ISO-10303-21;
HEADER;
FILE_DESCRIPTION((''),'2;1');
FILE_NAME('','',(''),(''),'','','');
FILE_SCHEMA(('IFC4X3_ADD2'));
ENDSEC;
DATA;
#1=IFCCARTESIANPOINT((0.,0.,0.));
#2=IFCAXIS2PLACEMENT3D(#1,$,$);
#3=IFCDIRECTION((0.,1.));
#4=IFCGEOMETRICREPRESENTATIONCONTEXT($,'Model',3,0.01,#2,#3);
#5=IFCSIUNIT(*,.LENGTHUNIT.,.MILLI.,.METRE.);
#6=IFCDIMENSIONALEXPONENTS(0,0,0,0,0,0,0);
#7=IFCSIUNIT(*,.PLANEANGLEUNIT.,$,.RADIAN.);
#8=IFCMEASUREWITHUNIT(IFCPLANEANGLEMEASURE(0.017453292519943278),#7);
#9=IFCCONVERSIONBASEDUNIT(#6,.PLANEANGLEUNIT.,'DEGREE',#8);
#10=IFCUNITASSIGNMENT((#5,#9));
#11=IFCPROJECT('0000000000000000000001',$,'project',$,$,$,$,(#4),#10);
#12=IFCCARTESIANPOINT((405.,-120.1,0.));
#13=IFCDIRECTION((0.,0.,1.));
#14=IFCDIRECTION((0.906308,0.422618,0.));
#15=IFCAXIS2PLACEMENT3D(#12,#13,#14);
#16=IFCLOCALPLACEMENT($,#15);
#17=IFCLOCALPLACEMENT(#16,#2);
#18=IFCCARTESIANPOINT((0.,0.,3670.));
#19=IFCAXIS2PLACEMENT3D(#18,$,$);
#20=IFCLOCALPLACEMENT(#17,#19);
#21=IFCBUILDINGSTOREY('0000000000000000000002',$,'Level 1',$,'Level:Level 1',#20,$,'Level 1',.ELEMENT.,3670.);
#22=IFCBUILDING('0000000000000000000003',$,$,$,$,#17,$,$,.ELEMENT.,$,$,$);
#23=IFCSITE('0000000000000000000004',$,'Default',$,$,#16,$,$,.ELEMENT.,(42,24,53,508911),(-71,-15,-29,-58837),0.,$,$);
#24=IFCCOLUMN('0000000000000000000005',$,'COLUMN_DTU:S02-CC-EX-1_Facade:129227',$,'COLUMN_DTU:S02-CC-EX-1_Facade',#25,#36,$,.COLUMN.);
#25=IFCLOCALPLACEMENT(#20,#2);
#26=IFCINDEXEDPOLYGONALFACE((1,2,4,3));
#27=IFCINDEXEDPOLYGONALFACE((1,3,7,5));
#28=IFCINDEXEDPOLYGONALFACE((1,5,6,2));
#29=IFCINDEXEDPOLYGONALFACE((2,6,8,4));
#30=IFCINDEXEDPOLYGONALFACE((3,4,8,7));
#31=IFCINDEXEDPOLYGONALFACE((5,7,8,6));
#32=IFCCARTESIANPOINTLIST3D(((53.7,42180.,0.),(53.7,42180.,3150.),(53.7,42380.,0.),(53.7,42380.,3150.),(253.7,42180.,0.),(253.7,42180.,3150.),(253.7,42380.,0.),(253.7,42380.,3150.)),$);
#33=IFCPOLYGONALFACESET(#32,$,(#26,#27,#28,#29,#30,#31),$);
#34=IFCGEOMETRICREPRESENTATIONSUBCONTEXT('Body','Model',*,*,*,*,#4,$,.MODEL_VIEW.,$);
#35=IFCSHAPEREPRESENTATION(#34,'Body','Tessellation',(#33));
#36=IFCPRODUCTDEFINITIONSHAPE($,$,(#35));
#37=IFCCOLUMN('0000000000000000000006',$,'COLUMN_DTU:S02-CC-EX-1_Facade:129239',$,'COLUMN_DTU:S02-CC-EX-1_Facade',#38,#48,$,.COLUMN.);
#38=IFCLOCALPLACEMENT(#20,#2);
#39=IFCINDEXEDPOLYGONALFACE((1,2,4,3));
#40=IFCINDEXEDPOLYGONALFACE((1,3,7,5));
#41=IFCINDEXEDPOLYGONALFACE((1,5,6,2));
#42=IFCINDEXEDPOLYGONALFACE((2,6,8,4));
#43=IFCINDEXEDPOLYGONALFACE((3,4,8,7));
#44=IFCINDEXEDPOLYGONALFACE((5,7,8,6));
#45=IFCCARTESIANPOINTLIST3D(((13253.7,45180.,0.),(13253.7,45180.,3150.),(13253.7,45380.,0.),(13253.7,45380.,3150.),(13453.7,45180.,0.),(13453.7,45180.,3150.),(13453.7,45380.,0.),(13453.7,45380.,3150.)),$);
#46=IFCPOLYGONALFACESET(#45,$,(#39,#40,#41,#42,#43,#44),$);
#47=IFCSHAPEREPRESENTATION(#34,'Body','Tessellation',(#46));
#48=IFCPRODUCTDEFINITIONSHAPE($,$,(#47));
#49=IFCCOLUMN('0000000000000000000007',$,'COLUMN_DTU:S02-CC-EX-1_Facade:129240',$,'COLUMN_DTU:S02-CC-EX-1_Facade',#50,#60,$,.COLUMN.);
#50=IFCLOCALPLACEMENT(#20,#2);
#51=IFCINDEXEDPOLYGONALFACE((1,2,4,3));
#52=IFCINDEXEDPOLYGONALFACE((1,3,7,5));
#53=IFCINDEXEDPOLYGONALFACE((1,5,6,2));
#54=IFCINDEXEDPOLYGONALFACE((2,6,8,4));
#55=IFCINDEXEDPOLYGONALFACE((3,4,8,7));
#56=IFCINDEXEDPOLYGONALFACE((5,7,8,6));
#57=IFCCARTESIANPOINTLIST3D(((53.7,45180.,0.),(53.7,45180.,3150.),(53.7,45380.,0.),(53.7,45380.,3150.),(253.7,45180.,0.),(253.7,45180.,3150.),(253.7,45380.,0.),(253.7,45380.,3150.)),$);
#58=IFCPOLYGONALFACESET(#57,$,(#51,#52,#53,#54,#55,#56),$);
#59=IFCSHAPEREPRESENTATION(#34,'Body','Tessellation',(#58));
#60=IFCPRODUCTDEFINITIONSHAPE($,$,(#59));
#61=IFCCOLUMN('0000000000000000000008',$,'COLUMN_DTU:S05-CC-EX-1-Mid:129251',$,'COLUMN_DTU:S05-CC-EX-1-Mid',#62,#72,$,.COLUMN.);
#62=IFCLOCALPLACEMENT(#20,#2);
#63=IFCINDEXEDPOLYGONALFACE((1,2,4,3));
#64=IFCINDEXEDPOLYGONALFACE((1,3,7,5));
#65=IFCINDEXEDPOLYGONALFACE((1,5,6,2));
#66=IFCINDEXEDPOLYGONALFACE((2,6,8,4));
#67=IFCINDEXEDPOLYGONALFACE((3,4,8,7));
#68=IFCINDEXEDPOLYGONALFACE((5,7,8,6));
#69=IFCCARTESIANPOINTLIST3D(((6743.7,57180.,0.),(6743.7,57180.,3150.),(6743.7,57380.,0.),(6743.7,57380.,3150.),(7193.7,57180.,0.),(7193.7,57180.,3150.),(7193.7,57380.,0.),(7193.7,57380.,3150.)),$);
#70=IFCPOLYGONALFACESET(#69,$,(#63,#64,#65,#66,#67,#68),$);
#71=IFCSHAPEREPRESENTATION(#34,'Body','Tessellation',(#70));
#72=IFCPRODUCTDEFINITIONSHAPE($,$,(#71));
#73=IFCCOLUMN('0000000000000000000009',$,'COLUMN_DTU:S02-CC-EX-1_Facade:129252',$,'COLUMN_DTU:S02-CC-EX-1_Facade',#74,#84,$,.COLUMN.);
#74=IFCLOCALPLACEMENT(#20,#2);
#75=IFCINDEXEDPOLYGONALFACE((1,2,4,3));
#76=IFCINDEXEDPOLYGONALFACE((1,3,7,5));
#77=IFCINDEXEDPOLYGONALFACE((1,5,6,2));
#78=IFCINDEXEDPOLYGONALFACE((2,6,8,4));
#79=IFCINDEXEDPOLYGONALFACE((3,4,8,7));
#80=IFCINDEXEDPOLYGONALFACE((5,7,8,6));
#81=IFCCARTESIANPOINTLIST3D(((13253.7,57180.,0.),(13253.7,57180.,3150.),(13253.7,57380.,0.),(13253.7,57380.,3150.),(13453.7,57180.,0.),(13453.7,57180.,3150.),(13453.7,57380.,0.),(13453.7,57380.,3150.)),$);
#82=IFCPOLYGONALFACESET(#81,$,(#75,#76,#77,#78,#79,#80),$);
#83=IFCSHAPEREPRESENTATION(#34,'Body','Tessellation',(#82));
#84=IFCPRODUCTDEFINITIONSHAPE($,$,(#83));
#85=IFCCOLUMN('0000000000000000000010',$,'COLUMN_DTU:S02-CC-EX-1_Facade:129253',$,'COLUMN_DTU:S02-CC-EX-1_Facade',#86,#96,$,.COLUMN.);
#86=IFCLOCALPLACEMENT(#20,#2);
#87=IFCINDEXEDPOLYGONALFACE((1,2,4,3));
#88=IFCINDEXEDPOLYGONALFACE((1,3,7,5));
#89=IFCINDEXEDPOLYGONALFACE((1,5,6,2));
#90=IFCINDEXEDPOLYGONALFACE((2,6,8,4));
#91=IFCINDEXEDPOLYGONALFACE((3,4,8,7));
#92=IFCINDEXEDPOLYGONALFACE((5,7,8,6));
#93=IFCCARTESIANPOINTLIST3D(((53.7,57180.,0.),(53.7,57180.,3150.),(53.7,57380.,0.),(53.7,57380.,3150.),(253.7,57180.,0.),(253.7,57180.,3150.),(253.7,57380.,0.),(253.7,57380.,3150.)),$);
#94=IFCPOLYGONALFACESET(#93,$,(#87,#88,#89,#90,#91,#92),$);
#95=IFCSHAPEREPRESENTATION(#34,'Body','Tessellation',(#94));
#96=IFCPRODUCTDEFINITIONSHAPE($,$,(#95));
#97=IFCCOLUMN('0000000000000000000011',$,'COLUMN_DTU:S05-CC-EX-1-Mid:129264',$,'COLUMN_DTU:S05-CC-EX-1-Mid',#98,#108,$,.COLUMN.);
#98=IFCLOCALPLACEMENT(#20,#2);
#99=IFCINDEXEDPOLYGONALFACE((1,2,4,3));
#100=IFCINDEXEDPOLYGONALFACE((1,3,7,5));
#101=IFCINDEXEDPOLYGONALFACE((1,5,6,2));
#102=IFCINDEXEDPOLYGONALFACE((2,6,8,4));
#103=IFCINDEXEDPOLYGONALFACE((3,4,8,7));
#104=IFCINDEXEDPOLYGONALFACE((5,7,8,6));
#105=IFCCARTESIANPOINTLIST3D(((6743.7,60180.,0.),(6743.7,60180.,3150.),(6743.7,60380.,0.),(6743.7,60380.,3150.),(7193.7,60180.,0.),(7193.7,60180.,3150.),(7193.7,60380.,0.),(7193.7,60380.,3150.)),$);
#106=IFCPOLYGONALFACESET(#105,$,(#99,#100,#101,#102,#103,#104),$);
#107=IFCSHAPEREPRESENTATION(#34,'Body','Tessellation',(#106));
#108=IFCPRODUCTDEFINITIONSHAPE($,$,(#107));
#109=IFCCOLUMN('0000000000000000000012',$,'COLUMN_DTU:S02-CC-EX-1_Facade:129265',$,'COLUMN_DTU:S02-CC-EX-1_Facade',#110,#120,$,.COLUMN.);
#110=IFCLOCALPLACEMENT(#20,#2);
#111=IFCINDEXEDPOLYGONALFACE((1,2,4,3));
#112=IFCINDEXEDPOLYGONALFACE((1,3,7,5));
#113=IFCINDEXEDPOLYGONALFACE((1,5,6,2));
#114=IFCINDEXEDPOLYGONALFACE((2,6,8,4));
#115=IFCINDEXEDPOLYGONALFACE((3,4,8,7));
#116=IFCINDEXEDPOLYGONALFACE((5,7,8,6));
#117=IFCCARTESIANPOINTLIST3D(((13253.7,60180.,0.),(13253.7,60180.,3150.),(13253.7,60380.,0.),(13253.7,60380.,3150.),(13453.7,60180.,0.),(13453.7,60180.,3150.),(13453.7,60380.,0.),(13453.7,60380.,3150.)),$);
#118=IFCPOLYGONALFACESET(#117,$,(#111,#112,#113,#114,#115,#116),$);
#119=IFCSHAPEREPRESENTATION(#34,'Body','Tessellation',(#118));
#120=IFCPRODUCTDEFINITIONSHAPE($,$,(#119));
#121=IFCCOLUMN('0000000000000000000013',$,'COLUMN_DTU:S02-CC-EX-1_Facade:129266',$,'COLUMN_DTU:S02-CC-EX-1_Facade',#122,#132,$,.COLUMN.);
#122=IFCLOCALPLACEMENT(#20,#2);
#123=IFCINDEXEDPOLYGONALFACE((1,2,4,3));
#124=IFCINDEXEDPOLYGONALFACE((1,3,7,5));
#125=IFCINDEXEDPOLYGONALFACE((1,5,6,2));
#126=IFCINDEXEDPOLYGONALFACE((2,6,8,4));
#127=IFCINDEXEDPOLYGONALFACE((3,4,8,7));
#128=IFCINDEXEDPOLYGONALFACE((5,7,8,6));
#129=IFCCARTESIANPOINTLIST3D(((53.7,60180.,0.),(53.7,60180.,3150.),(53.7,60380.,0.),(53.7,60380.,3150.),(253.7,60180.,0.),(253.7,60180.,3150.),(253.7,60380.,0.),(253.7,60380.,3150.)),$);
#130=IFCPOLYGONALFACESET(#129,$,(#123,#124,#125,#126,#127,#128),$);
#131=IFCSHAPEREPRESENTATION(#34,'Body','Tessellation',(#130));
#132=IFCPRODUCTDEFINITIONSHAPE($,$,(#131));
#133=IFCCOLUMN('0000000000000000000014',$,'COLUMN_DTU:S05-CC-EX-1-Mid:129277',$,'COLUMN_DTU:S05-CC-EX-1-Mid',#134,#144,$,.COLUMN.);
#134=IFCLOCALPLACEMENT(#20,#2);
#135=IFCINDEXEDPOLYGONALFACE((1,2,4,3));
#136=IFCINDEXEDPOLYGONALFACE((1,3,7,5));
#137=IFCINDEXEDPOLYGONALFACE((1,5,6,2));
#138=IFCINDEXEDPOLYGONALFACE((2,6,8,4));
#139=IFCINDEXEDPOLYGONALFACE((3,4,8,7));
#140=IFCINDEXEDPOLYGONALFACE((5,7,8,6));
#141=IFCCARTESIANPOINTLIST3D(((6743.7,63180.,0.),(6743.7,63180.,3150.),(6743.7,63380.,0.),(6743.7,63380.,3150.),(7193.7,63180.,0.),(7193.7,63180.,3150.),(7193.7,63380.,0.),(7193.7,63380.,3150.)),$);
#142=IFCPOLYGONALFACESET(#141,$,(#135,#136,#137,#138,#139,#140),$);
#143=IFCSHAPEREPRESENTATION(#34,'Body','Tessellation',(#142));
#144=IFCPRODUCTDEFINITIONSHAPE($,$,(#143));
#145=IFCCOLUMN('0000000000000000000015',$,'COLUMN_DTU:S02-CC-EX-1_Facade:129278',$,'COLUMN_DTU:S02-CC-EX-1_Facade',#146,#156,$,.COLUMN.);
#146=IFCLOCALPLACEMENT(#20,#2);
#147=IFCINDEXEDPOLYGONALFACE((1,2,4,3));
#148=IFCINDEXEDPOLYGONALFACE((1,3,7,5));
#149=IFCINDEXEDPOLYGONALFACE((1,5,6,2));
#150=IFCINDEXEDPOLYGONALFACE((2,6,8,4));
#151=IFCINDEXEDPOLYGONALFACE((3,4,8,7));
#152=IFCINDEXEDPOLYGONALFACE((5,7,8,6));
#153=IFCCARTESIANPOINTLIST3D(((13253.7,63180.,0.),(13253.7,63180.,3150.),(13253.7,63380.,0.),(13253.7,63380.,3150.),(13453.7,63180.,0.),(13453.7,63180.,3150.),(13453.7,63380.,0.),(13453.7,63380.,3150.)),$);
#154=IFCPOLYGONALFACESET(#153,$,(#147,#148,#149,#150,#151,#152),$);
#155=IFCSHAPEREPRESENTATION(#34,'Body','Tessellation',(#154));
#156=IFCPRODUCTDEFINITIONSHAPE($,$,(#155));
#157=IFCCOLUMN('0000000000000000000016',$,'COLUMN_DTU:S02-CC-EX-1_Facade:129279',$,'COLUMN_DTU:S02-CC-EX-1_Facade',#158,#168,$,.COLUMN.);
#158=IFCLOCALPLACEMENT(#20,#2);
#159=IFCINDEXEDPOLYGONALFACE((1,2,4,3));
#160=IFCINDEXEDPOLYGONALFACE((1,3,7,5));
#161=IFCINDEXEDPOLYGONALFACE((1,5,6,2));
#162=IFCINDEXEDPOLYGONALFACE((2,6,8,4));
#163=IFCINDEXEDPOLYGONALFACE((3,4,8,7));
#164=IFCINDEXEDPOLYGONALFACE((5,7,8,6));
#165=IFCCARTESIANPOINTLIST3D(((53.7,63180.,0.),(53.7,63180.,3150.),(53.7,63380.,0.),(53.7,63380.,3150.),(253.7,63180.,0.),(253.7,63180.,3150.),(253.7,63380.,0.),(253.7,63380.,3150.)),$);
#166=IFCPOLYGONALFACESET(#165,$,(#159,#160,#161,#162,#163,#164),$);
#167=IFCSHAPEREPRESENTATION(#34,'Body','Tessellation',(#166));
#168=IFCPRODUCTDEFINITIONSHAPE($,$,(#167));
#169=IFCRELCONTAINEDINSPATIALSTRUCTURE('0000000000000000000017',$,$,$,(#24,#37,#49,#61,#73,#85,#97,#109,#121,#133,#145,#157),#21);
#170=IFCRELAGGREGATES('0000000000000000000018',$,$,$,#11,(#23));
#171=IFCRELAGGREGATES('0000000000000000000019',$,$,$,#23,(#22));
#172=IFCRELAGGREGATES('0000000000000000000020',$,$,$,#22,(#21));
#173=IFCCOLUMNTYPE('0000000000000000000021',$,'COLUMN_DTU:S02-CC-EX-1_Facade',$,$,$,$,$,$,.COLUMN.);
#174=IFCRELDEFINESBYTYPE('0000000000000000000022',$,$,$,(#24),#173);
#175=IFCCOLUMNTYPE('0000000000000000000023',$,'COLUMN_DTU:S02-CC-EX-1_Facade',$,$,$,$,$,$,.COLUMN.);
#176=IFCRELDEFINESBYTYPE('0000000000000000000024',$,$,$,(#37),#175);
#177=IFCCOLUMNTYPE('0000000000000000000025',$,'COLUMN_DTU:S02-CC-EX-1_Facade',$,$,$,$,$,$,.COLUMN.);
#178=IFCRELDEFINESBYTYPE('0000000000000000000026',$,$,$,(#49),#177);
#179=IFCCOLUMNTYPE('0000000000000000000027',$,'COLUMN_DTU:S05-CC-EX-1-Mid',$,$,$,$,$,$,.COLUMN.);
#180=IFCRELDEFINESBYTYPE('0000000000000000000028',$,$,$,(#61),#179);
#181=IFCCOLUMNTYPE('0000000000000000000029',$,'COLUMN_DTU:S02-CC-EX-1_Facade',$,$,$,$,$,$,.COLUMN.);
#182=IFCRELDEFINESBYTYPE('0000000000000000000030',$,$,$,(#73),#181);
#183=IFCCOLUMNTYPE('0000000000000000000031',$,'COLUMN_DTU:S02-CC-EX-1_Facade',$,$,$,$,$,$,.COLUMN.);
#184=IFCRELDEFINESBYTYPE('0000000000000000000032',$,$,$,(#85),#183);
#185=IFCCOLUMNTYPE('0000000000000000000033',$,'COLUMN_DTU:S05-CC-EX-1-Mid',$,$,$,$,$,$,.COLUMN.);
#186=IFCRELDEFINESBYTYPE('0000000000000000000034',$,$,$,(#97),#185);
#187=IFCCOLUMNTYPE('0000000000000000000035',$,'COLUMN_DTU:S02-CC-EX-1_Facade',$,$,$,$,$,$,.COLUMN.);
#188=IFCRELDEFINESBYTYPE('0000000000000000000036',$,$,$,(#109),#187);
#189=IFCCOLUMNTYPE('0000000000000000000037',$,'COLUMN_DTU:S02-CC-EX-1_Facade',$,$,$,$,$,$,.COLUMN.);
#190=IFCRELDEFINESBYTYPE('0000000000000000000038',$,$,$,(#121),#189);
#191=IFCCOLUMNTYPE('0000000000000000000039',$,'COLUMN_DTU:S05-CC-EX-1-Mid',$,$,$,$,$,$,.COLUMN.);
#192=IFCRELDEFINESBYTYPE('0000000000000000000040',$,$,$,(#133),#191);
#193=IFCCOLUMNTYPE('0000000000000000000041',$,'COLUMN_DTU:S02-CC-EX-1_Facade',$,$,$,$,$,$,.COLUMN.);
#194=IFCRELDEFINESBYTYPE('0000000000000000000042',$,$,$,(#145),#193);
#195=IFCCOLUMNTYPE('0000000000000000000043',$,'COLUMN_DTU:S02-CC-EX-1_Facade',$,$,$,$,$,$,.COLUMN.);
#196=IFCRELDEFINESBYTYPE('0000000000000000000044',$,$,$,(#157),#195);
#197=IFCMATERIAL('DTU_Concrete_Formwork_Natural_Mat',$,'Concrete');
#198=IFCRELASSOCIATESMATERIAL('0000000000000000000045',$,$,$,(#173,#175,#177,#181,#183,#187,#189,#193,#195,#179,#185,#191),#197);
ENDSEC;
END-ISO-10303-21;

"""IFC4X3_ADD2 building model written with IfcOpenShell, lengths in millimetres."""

from ifc_helpers import new_model, entity, si_unit, converted_unit, direction, frame, frame_2d, origin, origin_2d_with_axis, place, context, subcontext, project, spatial, rectangle, extrude, source, transform, mapped, material, material_profile, profile_set, type_object, type_shapes, element, save


model = new_model("IFC4X3_ADD2")

# Units and contexts
model_context = context("Model", 3, precision=0.01, world=origin(), true_north=direction((0.0, 1.0)))
body_context = subcontext(model_context, "Body", "Model", "MODEL_VIEW")
ifc_project = project(units=[si_unit("LENGTHUNIT", "METRE", prefix="MILLI"), converted_unit("PLANEANGLEUNIT", "DEGREE", entity("IfcPlaneAngleMeasure", 0.017453292519943278), si_unit("PLANEANGLEUNIT", "RADIAN"), dimensions=[0, 0, 0, 0, 0, 0, 0])], contexts=[model_context])

# Site, building, storey
site_placement = place(None, frame((405.0, -120.1, 0.0), z_axis=(0.0, 0.0, 1.0), x_axis=(0.906308, 0.422618, 0.0)))
site = spatial("IfcSite", under=ifc_project, at=site_placement, Name="Default", CompositionType="ELEMENT", RefLatitude=(42, 24, 53, 508911), RefLongitude=(-71, -15, -29, -58837), RefElevation=0.0)
building_placement = place(site_placement, origin())
building = spatial("IfcBuilding", under=site, at=building_placement, CompositionType="ELEMENT")
storey_placement = place(building_placement, frame((0.0, 0.0, 3670.0)))
storey = spatial("IfcBuildingStorey", under=building, at=storey_placement, Name="Level 1", ObjectType="Level:Level 1", LongName="Level 1", CompositionType="ELEMENT", Elevation=3670.0)

# Columns
ifc_material = material(Name="DTU_Concrete_Formwork_Natural_Mat", Category="Concrete")
ifc_material_profile_1 = material_profile(ifc_material, rectangle(XDim=200.0, YDim=450.0, at=origin_2d_with_axis()), Name="S05-CC-EX-1-Mid")
ifc_profile_set_1 = profile_set([ifc_material_profile_1], Name="S05-CC-EX-1-Mid")
ifc_material_profile_2 = material_profile(ifc_material, rectangle(XDim=200.0, YDim=200.0, at=frame_2d((0.0, 0.0), x_axis=(1.0, 0.0))), Name="S02-CC-EX-1_Facade")
ifc_profile_set_2 = profile_set([ifc_material_profile_2], Name="S02-CC-EX-1_Facade")
column_type_1 = type_object("IfcColumnType", Name="COLUMN_DTU:S02-CC-EX-1_Facade", PredefinedType="COLUMN", material=ifc_profile_set_2)
shared_shape_1 = source(origin(), body_context, "Body", "SweptSolid", [
    extrude(rectangle(XDim=200.0, YDim=200.0, at=frame_2d((0.0, 0.0), x_axis=(1.0, 0.0))), frame((153.7, 42280.0, 3670.0), z_axis=(0.0, 0.0, 1.0), x_axis=(0.0, -1.0, 0.0)), (0.0, 0.0, 1.0), 3150.0),
])
type_shapes(column_type_1, [shared_shape_1])
column_1_placement = place(storey_placement, frame((0.0, 0.0, -3670.0)))
element("IfcColumn", 1, at=column_1_placement, inside=storey, type_object=column_type_1, Name="COLUMN_DTU:S02-CC-EX-1_Facade:129227", ObjectType="COLUMN_DTU:S02-CC-EX-1_Facade", PredefinedType="COLUMN", context=body_context, shape_type="MappedRepresentation", body=[
    mapped(shared_shape_1, transform((0.0, 0.0, 0.0), scale=1.0)),
])
column_type_2 = type_object("IfcColumnType", Name="COLUMN_DTU:S02-CC-EX-1_Facade", PredefinedType="COLUMN", material=ifc_profile_set_2)
shared_shape_2 = source(origin(), body_context, "Body", "SweptSolid", [
    extrude(rectangle(XDim=200.0, YDim=200.0, at=frame_2d((0.0, 0.0), x_axis=(1.0, 0.0))), frame((13353.7, 45280.0, 3670.0), z_axis=(0.0, 0.0, 1.0), x_axis=(0.0, -1.0, 0.0)), (0.0, 0.0, 1.0), 3150.0),
])
type_shapes(column_type_2, [shared_shape_2])
column_2_placement = place(storey_placement, frame((0.0, 0.0, -3670.0)))
element("IfcColumn", 2, at=column_2_placement, inside=storey, type_object=column_type_2, Name="COLUMN_DTU:S02-CC-EX-1_Facade:129239", ObjectType="COLUMN_DTU:S02-CC-EX-1_Facade", PredefinedType="COLUMN", context=body_context, shape_type="MappedRepresentation", body=[
    mapped(shared_shape_2, transform((0.0, 0.0, 0.0), scale=1.0)),
])
column_type_3 = type_object("IfcColumnType", Name="COLUMN_DTU:S02-CC-EX-1_Facade", PredefinedType="COLUMN", material=ifc_profile_set_2)
shared_shape_3 = source(origin(), body_context, "Body", "SweptSolid", [
    extrude(rectangle(XDim=200.0, YDim=200.0, at=frame_2d((0.0, 0.0), x_axis=(1.0, 0.0))), frame((153.7, 45280.0, 3670.0), z_axis=(0.0, 0.0, 1.0), x_axis=(0.0, -1.0, 0.0)), (0.0, 0.0, 1.0), 3150.0),
])
type_shapes(column_type_3, [shared_shape_3])
column_3_placement = place(storey_placement, frame((0.0, 0.0, -3670.0)))
element("IfcColumn", 3, at=column_3_placement, inside=storey, type_object=column_type_3, Name="COLUMN_DTU:S02-CC-EX-1_Facade:129240", ObjectType="COLUMN_DTU:S02-CC-EX-1_Facade", PredefinedType="COLUMN", context=body_context, shape_type="MappedRepresentation", body=[
    mapped(shared_shape_3, transform((0.0, 0.0, 0.0), scale=1.0)),
])
column_type_4 = type_object("IfcColumnType", Name="COLUMN_DTU:S05-CC-EX-1-Mid", PredefinedType="COLUMN", material=ifc_profile_set_1)
shared_shape_4 = source(origin(), body_context, "Body", "SweptSolid", [
    extrude(rectangle(XDim=200.0, YDim=450.0, at=frame_2d((0.0, 0.0), x_axis=(1.0, 0.0))), frame((6968.7, 57280.0, 3670.0), z_axis=(0.0, 0.0, 1.0), x_axis=(0.0, 1.0, 0.0)), (0.0, 0.0, 1.0), 3150.0),
])
type_shapes(column_type_4, [shared_shape_4])
column_4_placement = place(storey_placement, frame((0.0, 0.0, -3670.0)))
element("IfcColumn", 4, at=column_4_placement, inside=storey, type_object=column_type_4, Name="COLUMN_DTU:S05-CC-EX-1-Mid:129251", ObjectType="COLUMN_DTU:S05-CC-EX-1-Mid", PredefinedType="COLUMN", context=body_context, shape_type="MappedRepresentation", body=[
    mapped(shared_shape_4, transform((0.0, 0.0, 0.0), scale=1.0)),
])
column_type_5 = type_object("IfcColumnType", Name="COLUMN_DTU:S02-CC-EX-1_Facade", PredefinedType="COLUMN", material=ifc_profile_set_2)
shared_shape_5 = source(origin(), body_context, "Body", "SweptSolid", [
    extrude(rectangle(XDim=200.0, YDim=200.0, at=frame_2d((0.0, 0.0), x_axis=(1.0, 0.0))), frame((13353.7, 57280.0, 3670.0), z_axis=(0.0, 0.0, 1.0), x_axis=(0.0, -1.0, 0.0)), (0.0, 0.0, 1.0), 3150.0),
])
type_shapes(column_type_5, [shared_shape_5])
column_5_placement = place(storey_placement, frame((0.0, 0.0, -3670.0)))
element("IfcColumn", 5, at=column_5_placement, inside=storey, type_object=column_type_5, Name="COLUMN_DTU:S02-CC-EX-1_Facade:129252", ObjectType="COLUMN_DTU:S02-CC-EX-1_Facade", PredefinedType="COLUMN", context=body_context, shape_type="MappedRepresentation", body=[
    mapped(shared_shape_5, transform((0.0, 0.0, 0.0), scale=1.0)),
])
column_type_6 = type_object("IfcColumnType", Name="COLUMN_DTU:S02-CC-EX-1_Facade", PredefinedType="COLUMN", material=ifc_profile_set_2)
shared_shape_6 = source(origin(), body_context, "Body", "SweptSolid", [
    extrude(rectangle(XDim=200.0, YDim=200.0, at=frame_2d((0.0, 0.0), x_axis=(1.0, 0.0))), frame((153.7, 57280.0, 3670.0), z_axis=(0.0, 0.0, 1.0), x_axis=(0.0, -1.0, 0.0)), (0.0, 0.0, 1.0), 3150.0),
])
type_shapes(column_type_6, [shared_shape_6])
column_6_placement = place(storey_placement, frame((0.0, 0.0, -3670.0)))
element("IfcColumn", 6, at=column_6_placement, inside=storey, type_object=column_type_6, Name="COLUMN_DTU:S02-CC-EX-1_Facade:129253", ObjectType="COLUMN_DTU:S02-CC-EX-1_Facade", PredefinedType="COLUMN", context=body_context, shape_type="MappedRepresentation", body=[
    mapped(shared_shape_6, transform((0.0, 0.0, 0.0), scale=1.0)),
])
column_type_7 = type_object("IfcColumnType", Name="COLUMN_DTU:S05-CC-EX-1-Mid", PredefinedType="COLUMN", material=ifc_profile_set_1)
shared_shape_7 = source(origin(), body_context, "Body", "SweptSolid", [
    extrude(rectangle(XDim=200.0, YDim=450.0, at=frame_2d((0.0, 0.0), x_axis=(1.0, 0.0))), frame((6968.7, 60280.0, 3670.0), z_axis=(0.0, 0.0, 1.0), x_axis=(0.0, 1.0, 0.0)), (0.0, 0.0, 1.0), 3150.0),
])
type_shapes(column_type_7, [shared_shape_7])
column_7_placement = place(storey_placement, frame((0.0, 0.0, -3670.0)))
element("IfcColumn", 7, at=column_7_placement, inside=storey, type_object=column_type_7, Name="COLUMN_DTU:S05-CC-EX-1-Mid:129264", ObjectType="COLUMN_DTU:S05-CC-EX-1-Mid", PredefinedType="COLUMN", context=body_context, shape_type="MappedRepresentation", body=[
    mapped(shared_shape_7, transform((0.0, 0.0, 0.0), scale=1.0)),
])
column_type_8 = type_object("IfcColumnType", Name="COLUMN_DTU:S02-CC-EX-1_Facade", PredefinedType="COLUMN", material=ifc_profile_set_2)
shared_shape_8 = source(origin(), body_context, "Body", "SweptSolid", [
    extrude(rectangle(XDim=200.0, YDim=200.0, at=frame_2d((0.0, 0.0), x_axis=(1.0, 0.0))), frame((13353.7, 60280.0, 3670.0), z_axis=(0.0, 0.0, 1.0), x_axis=(0.0, -1.0, 0.0)), (0.0, 0.0, 1.0), 3150.0),
])
type_shapes(column_type_8, [shared_shape_8])
column_8_placement = place(storey_placement, frame((0.0, 0.0, -3670.0)))
element("IfcColumn", 8, at=column_8_placement, inside=storey, type_object=column_type_8, Name="COLUMN_DTU:S02-CC-EX-1_Facade:129265", ObjectType="COLUMN_DTU:S02-CC-EX-1_Facade", PredefinedType="COLUMN", context=body_context, shape_type="MappedRepresentation", body=[
    mapped(shared_shape_8, transform((0.0, 0.0, 0.0), scale=1.0)),
])
column_type_9 = type_object("IfcColumnType", Name="COLUMN_DTU:S02-CC-EX-1_Facade", PredefinedType="COLUMN", material=ifc_profile_set_2)
shared_shape_9 = source(origin(), body_context, "Body", "SweptSolid", [
    extrude(rectangle(XDim=200.0, YDim=200.0, at=frame_2d((0.0, 0.0), x_axis=(1.0, 0.0))), frame((153.7, 60280.0, 3670.0), z_axis=(0.0, 0.0, 1.0), x_axis=(0.0, -1.0, 0.0)), (0.0, 0.0, 1.0), 3150.0),
])
type_shapes(column_type_9, [shared_shape_9])
column_9_placement = place(storey_placement, frame((0.0, 0.0, -3670.0)))
element("IfcColumn", 9, at=column_9_placement, inside=storey, type_object=column_type_9, Name="COLUMN_DTU:S02-CC-EX-1_Facade:129266", ObjectType="COLUMN_DTU:S02-CC-EX-1_Facade", PredefinedType="COLUMN", context=body_context, shape_type="MappedRepresentation", body=[
    mapped(shared_shape_9, transform((0.0, 0.0, 0.0), scale=1.0)),
])
column_type_10 = type_object("IfcColumnType", Name="COLUMN_DTU:S05-CC-EX-1-Mid", PredefinedType="COLUMN", material=ifc_profile_set_1)
shared_shape_10 = source(origin(), body_context, "Body", "SweptSolid", [
    extrude(rectangle(XDim=200.0, YDim=450.0, at=frame_2d((0.0, 0.0), x_axis=(1.0, 0.0))), frame((6968.7, 63280.0, 3670.0), z_axis=(0.0, 0.0, 1.0), x_axis=(0.0, 1.0, 0.0)), (0.0, 0.0, 1.0), 3150.0),
])
type_shapes(column_type_10, [shared_shape_10])
column_10_placement = place(storey_placement, frame((0.0, 0.0, -3670.0)))
element("IfcColumn", 10, at=column_10_placement, inside=storey, type_object=column_type_10, Name="COLUMN_DTU:S05-CC-EX-1-Mid:129277", ObjectType="COLUMN_DTU:S05-CC-EX-1-Mid", PredefinedType="COLUMN", context=body_context, shape_type="MappedRepresentation", body=[
    mapped(shared_shape_10, transform((0.0, 0.0, 0.0), scale=1.0)),
])
column_type_11 = type_object("IfcColumnType", Name="COLUMN_DTU:S02-CC-EX-1_Facade", PredefinedType="COLUMN", material=ifc_profile_set_2)
shared_shape_11 = source(origin(), body_context, "Body", "SweptSolid", [
    extrude(rectangle(XDim=200.0, YDim=200.0, at=frame_2d((0.0, 0.0), x_axis=(1.0, 0.0))), frame((13353.7, 63280.0, 3670.0), z_axis=(0.0, 0.0, 1.0), x_axis=(0.0, -1.0, 0.0)), (0.0, 0.0, 1.0), 3150.0),
])
type_shapes(column_type_11, [shared_shape_11])
column_11_placement = place(storey_placement, frame((0.0, 0.0, -3670.0)))
element("IfcColumn", 11, at=column_11_placement, inside=storey, type_object=column_type_11, Name="COLUMN_DTU:S02-CC-EX-1_Facade:129278", ObjectType="COLUMN_DTU:S02-CC-EX-1_Facade", PredefinedType="COLUMN", context=body_context, shape_type="MappedRepresentation", body=[
    mapped(shared_shape_11, transform((0.0, 0.0, 0.0), scale=1.0)),
])
column_type_12 = type_object("IfcColumnType", Name="COLUMN_DTU:S02-CC-EX-1_Facade", PredefinedType="COLUMN", material=ifc_profile_set_2)
shared_shape_12 = source(origin(), body_context, "Body", "SweptSolid", [
    extrude(rectangle(XDim=200.0, YDim=200.0, at=frame_2d((0.0, 0.0), x_axis=(1.0, 0.0))), frame((153.7, 63280.0, 3670.0), z_axis=(0.0, 0.0, 1.0), x_axis=(0.0, -1.0, 0.0)), (0.0, 0.0, 1.0), 3150.0),
])
type_shapes(column_type_12, [shared_shape_12])
column_12_placement = place(storey_placement, frame((0.0, 0.0, -3670.0)))
element("IfcColumn", 12, at=column_12_placement, inside=storey, type_object=column_type_12, Name="COLUMN_DTU:S02-CC-EX-1_Facade:129279", ObjectType="COLUMN_DTU:S02-CC-EX-1_Facade", PredefinedType="COLUMN", context=body_context, shape_type="MappedRepresentation", body=[
    mapped(shared_shape_12, transform((0.0, 0.0, 0.0), scale=1.0)),
])

save(model, "model.ifc")
